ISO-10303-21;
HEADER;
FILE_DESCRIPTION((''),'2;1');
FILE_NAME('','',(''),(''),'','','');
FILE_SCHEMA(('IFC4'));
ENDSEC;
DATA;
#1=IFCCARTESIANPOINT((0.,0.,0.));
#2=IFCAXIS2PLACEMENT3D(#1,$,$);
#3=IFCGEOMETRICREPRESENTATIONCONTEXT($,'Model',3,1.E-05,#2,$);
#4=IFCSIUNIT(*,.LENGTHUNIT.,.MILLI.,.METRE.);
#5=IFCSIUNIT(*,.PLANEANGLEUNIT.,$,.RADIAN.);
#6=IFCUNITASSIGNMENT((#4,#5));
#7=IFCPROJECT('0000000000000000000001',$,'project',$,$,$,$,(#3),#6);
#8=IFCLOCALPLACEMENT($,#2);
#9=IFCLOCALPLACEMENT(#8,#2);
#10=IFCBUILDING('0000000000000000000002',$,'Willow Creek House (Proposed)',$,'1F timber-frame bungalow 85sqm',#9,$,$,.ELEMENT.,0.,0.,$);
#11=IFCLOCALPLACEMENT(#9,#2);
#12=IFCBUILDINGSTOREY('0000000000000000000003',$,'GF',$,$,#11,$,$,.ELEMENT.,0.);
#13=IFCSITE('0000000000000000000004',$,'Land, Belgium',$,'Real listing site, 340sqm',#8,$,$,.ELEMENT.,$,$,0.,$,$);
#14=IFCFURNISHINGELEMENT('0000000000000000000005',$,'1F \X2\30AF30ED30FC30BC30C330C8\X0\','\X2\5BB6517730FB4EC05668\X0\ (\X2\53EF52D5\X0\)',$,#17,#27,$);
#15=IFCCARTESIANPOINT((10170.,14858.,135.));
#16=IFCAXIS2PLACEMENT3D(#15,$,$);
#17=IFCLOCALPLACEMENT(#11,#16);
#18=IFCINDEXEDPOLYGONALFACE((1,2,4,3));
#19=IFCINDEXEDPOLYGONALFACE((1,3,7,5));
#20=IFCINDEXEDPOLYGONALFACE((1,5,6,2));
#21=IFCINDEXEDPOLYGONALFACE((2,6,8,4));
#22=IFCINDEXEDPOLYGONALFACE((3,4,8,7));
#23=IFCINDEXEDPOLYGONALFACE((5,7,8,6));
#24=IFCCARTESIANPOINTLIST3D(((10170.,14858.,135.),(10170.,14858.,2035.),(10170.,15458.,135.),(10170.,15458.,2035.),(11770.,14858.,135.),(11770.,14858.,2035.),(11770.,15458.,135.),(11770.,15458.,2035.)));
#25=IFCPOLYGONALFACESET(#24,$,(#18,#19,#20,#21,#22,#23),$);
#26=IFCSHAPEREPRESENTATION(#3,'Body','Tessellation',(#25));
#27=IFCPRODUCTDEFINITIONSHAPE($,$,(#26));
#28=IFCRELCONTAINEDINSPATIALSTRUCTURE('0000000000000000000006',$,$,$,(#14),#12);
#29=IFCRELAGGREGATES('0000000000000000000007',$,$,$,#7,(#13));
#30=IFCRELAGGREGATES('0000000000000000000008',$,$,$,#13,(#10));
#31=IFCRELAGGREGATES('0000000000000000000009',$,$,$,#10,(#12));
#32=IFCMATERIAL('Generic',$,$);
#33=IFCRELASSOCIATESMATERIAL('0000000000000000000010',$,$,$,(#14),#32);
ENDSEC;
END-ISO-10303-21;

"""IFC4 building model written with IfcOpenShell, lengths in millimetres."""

from ifc_helpers import new_model, si_unit, frame, frame_2d, origin, place, context, project, spatial, rectangle, extrude, material, element, save


model = new_model("IFC4")

# Units and contexts
model_context = context("Model", 3, precision=1e-05, world=origin())
ifc_project = project(units=[si_unit("LENGTHUNIT", "METRE", prefix="MILLI"), si_unit("PLANEANGLEUNIT", "RADIAN")], contexts=[model_context])

# Site, building, storey
site_placement = place(None, origin())
site = spatial("IfcSite", under=ifc_project, at=site_placement, Name="Land, Belgium", ObjectType="Real listing site, 340sqm", CompositionType="ELEMENT", RefElevation=0.0)
building_placement = place(site_placement, origin())
building = spatial("IfcBuilding", under=site, at=building_placement, Name="Willow Creek House (Proposed)", ObjectType="1F timber-frame bungalow 85sqm", CompositionType="ELEMENT", ElevationOfRefHeight=0.0, ElevationOfTerrain=0.0)
storey_placement = place(building_placement, origin())
storey = spatial("IfcBuildingStorey", under=building, at=storey_placement, Name="GF", CompositionType="ELEMENT", Elevation=0.0)

# Shared definitions
ifc_material_1 = material(Name="Generic")

# Furnishing element
furnishing_placement = place(storey_placement, frame((10170.0, 14858.0, 135.0)))
element("IfcFurnishingElement", 1, at=furnishing_placement, inside=storey, material=ifc_material_1, Name="1F クローゼット", Description="家具・什器 (可動)", context=model_context, shape_type="SweptSolid", body=[
    extrude(rectangle(XDim=1600.0, YDim=600.0, at=frame_2d((800.0, 300.0))), frame((10170.0, 14858.0, 135.0)), (0.0, 0.0, 1.0), 1900.0),
])

save(model, "model.ifc")
